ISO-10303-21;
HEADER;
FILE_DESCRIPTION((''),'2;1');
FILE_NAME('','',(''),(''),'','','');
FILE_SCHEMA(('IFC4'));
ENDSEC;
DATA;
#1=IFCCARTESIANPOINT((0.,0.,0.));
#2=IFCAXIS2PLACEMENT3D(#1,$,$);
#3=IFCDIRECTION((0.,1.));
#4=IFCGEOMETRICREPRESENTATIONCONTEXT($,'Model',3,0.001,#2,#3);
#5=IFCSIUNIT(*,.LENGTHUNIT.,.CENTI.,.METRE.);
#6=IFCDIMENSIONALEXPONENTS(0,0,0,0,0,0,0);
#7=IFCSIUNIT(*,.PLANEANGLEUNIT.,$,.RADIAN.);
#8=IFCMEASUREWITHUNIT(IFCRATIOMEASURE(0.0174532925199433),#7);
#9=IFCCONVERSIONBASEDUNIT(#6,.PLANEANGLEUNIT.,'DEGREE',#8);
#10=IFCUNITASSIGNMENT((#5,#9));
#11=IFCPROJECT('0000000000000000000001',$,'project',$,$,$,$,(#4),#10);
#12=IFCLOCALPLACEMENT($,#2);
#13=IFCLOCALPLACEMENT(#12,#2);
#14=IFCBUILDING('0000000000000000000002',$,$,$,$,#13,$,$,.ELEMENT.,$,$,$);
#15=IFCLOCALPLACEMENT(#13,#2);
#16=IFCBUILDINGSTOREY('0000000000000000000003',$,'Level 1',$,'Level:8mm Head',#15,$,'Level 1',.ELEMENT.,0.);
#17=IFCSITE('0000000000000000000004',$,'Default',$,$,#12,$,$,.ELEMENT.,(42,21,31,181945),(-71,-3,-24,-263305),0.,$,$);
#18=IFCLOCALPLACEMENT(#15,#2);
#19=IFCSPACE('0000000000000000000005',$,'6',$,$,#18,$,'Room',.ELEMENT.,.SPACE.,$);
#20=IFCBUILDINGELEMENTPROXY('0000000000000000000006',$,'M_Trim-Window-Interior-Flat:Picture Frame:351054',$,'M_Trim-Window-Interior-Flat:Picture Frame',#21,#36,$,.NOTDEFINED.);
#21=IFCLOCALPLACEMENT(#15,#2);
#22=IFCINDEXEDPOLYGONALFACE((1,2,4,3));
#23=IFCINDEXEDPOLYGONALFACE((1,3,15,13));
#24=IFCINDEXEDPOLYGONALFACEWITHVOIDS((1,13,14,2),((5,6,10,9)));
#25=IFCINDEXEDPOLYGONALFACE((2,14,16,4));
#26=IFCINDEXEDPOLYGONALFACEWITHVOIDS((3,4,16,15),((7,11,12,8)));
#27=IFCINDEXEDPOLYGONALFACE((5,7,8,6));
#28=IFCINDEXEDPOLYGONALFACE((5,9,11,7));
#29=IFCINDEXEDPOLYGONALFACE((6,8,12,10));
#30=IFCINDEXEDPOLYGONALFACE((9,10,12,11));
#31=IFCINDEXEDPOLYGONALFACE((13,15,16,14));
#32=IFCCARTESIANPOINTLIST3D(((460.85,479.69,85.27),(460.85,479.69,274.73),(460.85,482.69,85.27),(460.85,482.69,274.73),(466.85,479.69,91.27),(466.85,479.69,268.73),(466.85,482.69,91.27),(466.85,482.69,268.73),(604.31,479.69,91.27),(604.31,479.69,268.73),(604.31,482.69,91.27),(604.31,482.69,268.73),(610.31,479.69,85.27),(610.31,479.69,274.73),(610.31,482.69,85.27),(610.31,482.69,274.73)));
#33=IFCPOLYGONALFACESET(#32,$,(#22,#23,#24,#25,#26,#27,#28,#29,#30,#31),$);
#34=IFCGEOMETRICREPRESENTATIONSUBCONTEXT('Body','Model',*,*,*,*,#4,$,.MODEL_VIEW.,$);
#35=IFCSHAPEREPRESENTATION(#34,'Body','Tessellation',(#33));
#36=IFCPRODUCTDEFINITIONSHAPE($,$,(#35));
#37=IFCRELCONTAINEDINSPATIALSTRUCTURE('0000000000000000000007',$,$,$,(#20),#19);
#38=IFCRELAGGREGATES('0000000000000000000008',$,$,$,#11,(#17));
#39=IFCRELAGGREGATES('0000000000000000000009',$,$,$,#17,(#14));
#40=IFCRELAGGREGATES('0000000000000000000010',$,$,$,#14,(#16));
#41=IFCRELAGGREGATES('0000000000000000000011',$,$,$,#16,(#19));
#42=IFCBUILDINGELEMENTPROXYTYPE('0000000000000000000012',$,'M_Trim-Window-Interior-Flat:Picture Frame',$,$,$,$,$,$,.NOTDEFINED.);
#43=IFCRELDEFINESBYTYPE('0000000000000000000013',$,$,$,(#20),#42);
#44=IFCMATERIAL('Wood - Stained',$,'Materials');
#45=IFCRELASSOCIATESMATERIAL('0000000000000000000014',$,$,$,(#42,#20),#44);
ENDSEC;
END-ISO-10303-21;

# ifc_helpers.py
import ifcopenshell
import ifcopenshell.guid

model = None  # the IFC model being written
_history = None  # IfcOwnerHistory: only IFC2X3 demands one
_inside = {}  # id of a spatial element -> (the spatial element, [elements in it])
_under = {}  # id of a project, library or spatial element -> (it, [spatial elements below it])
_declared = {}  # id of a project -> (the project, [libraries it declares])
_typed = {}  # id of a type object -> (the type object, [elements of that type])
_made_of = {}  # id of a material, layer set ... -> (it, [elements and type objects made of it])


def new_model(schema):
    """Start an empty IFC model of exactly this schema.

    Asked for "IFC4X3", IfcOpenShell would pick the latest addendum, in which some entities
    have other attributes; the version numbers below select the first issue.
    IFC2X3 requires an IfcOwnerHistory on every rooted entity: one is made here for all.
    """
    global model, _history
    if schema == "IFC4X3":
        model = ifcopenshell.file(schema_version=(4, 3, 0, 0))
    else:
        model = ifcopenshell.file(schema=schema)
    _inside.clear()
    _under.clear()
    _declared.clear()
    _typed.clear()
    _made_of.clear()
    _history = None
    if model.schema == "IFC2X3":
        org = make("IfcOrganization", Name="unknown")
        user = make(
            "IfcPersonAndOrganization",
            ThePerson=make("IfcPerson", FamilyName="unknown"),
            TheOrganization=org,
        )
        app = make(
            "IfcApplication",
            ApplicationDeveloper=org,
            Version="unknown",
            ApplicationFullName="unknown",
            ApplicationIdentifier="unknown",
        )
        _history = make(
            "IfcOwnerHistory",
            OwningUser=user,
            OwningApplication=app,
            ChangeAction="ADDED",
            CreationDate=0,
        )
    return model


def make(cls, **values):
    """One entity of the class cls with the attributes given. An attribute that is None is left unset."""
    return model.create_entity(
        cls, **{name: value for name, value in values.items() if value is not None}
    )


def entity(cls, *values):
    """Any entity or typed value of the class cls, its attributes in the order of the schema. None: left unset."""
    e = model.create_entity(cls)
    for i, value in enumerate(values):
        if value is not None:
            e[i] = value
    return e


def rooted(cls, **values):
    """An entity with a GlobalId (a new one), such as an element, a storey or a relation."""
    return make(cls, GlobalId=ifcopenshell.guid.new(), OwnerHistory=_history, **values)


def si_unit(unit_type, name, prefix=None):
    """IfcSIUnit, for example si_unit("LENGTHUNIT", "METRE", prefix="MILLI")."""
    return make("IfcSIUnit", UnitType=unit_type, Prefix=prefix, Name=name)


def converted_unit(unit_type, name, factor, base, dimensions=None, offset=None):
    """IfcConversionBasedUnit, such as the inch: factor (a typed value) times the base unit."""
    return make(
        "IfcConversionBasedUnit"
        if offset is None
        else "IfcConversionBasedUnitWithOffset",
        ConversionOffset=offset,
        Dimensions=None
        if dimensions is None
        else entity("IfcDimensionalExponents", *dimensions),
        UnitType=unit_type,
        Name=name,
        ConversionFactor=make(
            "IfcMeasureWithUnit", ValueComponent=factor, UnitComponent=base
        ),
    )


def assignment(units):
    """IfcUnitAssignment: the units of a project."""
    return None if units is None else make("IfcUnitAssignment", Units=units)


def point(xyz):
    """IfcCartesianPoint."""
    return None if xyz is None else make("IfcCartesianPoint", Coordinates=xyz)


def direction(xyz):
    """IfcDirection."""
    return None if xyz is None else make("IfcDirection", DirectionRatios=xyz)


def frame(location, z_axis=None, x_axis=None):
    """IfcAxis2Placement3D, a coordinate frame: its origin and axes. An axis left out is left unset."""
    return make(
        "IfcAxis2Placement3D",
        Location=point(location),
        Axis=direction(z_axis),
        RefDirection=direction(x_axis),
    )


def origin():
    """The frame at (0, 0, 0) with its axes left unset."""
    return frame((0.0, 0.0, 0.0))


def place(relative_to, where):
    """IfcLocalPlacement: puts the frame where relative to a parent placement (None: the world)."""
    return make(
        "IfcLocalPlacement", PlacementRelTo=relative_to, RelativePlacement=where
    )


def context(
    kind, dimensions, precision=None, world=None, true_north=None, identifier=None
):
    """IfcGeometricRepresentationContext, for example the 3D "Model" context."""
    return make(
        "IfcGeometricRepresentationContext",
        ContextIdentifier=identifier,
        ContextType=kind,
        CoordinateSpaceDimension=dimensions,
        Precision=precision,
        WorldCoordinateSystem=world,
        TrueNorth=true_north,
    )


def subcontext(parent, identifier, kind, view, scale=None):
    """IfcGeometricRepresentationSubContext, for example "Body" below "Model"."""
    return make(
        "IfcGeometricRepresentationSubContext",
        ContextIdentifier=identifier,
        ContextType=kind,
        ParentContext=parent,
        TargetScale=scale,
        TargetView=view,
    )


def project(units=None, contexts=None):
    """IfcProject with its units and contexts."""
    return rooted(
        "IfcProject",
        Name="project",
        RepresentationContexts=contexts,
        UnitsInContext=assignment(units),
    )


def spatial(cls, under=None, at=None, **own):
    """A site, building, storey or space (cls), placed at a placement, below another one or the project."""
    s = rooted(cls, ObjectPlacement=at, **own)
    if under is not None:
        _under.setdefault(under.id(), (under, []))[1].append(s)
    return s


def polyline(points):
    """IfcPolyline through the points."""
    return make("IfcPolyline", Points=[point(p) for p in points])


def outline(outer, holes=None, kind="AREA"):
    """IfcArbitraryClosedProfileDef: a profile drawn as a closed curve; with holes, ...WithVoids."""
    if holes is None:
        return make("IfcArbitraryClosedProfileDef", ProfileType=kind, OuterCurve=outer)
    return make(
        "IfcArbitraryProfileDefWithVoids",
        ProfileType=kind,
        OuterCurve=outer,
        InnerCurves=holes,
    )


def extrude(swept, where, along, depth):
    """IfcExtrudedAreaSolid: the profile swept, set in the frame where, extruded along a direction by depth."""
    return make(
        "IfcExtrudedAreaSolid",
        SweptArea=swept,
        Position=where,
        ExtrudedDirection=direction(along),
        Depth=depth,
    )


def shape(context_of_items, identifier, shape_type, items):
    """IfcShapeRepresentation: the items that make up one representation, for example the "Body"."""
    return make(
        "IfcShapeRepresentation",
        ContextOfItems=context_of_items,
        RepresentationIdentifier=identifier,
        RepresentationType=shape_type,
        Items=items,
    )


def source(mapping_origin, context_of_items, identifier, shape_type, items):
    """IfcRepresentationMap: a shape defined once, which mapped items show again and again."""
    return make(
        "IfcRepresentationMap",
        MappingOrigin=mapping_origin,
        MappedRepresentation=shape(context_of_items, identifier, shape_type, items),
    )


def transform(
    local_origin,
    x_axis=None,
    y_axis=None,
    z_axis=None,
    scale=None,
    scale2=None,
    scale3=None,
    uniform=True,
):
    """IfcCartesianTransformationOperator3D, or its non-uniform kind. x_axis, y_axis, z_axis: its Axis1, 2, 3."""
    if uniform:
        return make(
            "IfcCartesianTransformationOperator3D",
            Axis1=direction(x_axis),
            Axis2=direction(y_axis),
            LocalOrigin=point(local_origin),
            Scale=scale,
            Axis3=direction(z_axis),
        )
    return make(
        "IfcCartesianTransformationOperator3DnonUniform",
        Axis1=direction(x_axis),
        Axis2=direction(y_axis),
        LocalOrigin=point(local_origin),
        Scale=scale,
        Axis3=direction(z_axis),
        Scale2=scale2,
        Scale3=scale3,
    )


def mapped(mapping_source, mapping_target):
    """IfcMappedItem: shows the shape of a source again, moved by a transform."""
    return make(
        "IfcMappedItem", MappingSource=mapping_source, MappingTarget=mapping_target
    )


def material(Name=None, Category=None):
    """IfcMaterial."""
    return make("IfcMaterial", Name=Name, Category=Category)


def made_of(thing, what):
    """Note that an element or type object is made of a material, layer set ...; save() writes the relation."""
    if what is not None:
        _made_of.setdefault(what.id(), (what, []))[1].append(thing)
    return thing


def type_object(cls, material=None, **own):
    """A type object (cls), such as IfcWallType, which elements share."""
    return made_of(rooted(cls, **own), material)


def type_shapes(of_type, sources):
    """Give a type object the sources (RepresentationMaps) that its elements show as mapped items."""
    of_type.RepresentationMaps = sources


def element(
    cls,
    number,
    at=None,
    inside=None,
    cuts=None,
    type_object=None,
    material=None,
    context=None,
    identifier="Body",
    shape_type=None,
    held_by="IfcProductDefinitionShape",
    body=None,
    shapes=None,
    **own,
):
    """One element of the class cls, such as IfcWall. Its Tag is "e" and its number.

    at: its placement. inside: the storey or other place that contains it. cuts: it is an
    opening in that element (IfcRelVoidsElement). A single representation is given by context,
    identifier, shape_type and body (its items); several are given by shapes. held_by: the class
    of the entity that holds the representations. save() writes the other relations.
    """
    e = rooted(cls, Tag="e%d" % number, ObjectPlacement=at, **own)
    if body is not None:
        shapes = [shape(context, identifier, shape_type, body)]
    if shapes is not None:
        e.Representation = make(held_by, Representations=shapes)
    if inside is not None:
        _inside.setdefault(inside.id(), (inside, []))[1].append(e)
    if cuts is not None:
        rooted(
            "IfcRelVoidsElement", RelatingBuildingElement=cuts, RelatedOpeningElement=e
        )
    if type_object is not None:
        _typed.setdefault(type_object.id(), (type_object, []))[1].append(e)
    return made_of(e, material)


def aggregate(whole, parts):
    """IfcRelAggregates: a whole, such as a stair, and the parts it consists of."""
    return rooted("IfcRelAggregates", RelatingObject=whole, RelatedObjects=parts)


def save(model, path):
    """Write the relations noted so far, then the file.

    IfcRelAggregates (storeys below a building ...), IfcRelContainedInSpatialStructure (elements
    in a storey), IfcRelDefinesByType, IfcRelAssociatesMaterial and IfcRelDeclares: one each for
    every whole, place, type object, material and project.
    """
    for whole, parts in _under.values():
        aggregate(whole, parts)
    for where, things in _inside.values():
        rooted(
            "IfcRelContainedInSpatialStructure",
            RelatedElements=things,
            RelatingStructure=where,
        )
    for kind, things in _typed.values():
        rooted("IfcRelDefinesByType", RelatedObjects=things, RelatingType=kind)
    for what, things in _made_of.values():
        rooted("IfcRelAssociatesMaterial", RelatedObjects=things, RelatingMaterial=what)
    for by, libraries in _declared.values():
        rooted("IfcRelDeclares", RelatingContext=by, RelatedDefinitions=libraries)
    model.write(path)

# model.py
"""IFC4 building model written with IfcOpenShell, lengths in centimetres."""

from ifc_helpers import new_model, entity, si_unit, converted_unit, direction, frame, origin, place, context, subcontext, project, spatial, polyline, outline, extrude, source, transform, mapped, material, type_object, type_shapes, element, save


model = new_model("IFC4")

# Units and contexts
model_context = context("Model", 3, precision=0.001, world=origin(), true_north=direction((0.0, 1.0)))
body_context = subcontext(model_context, "Body", "Model", "MODEL_VIEW")
ifc_project = project(units=[si_unit("LENGTHUNIT", "METRE", prefix="CENTI"), converted_unit("PLANEANGLEUNIT", "DEGREE", entity("IfcRatioMeasure", 0.0174532925199433), si_unit("PLANEANGLEUNIT", "RADIAN"), dimensions=[0, 0, 0, 0, 0, 0, 0])], contexts=[model_context])

# Site, building, storey
site_placement = place(None, origin())
site = spatial("IfcSite", under=ifc_project, at=site_placement, Name="Default", CompositionType="ELEMENT", RefLatitude=(42, 21, 31, 181945), RefLongitude=(-71, -3, -24, -263305), RefElevation=0.0)
building_placement = place(site_placement, origin())
building = spatial("IfcBuilding", under=site, at=building_placement, CompositionType="ELEMENT")
storey_placement = place(building_placement, origin())
storey = spatial("IfcBuildingStorey", under=building, at=storey_placement, Name="Level 1", ObjectType="Level:8mm Head", LongName="Level 1", CompositionType="ELEMENT", Elevation=0.0)

# Shared definitions
ifc_material_1 = material(Name="Wood - Stained", Category="Materials")
building_element_proxy_type_1 = type_object("IfcBuildingElementProxyType", Name="M_Trim-Window-Interior-Flat:Picture Frame", PredefinedType="NOTDEFINED", material=ifc_material_1)
shared_shape_1 = source(origin(), body_context, "Body", "SweptSolid", [
    extrude(outline(polyline([(-74.73, -94.73), (74.73, -94.73), (74.73, 94.73), (-74.73, 94.73), (-74.73, -94.73)]), holes=[polyline([(-68.73, -88.73), (-68.73, 88.73), (68.73, 88.73), (68.73, -88.73), (-68.73, -88.73)])]), frame((0.0, -90.0, 0.0), z_axis=(0.0, 0.0, 1.0), x_axis=(-1.0, 0.0, 0.0)), (0.0, 0.0, 1.0), 3.0),
])
type_shapes(building_element_proxy_type_1, [shared_shape_1])

# Shared definitions
space_1_placement = place(storey_placement, origin())
space_1 = spatial("IfcSpace", under=storey, at=space_1_placement, Name="6", LongName="Room", CompositionType="ELEMENT", PredefinedType="SPACE")

# Building element proxy
for number, where, z_axis, x_axis, name in (
    (1, (535.58, 479.69, 270.0), (0.0, 1.0, 0.0), (-1.0, 0.0, 0.0), "M_Trim-Window-Interior-Flat:Picture Frame:351054"),
):
    element("IfcBuildingElementProxy", number, at=place(space_1_placement, frame(where, z_axis=z_axis, x_axis=x_axis)), inside=space_1, type_object=building_element_proxy_type_1, material=ifc_material_1, Name=name, ObjectType="M_Trim-Window-Interior-Flat:Picture Frame", PredefinedType="NOTDEFINED", context=body_context, shape_type="MappedRepresentation", body=[
        mapped(shared_shape_1, transform((0.0, 0.0, 0.0), scale=1.0)),
    ])

save(model, "model.ifc")
